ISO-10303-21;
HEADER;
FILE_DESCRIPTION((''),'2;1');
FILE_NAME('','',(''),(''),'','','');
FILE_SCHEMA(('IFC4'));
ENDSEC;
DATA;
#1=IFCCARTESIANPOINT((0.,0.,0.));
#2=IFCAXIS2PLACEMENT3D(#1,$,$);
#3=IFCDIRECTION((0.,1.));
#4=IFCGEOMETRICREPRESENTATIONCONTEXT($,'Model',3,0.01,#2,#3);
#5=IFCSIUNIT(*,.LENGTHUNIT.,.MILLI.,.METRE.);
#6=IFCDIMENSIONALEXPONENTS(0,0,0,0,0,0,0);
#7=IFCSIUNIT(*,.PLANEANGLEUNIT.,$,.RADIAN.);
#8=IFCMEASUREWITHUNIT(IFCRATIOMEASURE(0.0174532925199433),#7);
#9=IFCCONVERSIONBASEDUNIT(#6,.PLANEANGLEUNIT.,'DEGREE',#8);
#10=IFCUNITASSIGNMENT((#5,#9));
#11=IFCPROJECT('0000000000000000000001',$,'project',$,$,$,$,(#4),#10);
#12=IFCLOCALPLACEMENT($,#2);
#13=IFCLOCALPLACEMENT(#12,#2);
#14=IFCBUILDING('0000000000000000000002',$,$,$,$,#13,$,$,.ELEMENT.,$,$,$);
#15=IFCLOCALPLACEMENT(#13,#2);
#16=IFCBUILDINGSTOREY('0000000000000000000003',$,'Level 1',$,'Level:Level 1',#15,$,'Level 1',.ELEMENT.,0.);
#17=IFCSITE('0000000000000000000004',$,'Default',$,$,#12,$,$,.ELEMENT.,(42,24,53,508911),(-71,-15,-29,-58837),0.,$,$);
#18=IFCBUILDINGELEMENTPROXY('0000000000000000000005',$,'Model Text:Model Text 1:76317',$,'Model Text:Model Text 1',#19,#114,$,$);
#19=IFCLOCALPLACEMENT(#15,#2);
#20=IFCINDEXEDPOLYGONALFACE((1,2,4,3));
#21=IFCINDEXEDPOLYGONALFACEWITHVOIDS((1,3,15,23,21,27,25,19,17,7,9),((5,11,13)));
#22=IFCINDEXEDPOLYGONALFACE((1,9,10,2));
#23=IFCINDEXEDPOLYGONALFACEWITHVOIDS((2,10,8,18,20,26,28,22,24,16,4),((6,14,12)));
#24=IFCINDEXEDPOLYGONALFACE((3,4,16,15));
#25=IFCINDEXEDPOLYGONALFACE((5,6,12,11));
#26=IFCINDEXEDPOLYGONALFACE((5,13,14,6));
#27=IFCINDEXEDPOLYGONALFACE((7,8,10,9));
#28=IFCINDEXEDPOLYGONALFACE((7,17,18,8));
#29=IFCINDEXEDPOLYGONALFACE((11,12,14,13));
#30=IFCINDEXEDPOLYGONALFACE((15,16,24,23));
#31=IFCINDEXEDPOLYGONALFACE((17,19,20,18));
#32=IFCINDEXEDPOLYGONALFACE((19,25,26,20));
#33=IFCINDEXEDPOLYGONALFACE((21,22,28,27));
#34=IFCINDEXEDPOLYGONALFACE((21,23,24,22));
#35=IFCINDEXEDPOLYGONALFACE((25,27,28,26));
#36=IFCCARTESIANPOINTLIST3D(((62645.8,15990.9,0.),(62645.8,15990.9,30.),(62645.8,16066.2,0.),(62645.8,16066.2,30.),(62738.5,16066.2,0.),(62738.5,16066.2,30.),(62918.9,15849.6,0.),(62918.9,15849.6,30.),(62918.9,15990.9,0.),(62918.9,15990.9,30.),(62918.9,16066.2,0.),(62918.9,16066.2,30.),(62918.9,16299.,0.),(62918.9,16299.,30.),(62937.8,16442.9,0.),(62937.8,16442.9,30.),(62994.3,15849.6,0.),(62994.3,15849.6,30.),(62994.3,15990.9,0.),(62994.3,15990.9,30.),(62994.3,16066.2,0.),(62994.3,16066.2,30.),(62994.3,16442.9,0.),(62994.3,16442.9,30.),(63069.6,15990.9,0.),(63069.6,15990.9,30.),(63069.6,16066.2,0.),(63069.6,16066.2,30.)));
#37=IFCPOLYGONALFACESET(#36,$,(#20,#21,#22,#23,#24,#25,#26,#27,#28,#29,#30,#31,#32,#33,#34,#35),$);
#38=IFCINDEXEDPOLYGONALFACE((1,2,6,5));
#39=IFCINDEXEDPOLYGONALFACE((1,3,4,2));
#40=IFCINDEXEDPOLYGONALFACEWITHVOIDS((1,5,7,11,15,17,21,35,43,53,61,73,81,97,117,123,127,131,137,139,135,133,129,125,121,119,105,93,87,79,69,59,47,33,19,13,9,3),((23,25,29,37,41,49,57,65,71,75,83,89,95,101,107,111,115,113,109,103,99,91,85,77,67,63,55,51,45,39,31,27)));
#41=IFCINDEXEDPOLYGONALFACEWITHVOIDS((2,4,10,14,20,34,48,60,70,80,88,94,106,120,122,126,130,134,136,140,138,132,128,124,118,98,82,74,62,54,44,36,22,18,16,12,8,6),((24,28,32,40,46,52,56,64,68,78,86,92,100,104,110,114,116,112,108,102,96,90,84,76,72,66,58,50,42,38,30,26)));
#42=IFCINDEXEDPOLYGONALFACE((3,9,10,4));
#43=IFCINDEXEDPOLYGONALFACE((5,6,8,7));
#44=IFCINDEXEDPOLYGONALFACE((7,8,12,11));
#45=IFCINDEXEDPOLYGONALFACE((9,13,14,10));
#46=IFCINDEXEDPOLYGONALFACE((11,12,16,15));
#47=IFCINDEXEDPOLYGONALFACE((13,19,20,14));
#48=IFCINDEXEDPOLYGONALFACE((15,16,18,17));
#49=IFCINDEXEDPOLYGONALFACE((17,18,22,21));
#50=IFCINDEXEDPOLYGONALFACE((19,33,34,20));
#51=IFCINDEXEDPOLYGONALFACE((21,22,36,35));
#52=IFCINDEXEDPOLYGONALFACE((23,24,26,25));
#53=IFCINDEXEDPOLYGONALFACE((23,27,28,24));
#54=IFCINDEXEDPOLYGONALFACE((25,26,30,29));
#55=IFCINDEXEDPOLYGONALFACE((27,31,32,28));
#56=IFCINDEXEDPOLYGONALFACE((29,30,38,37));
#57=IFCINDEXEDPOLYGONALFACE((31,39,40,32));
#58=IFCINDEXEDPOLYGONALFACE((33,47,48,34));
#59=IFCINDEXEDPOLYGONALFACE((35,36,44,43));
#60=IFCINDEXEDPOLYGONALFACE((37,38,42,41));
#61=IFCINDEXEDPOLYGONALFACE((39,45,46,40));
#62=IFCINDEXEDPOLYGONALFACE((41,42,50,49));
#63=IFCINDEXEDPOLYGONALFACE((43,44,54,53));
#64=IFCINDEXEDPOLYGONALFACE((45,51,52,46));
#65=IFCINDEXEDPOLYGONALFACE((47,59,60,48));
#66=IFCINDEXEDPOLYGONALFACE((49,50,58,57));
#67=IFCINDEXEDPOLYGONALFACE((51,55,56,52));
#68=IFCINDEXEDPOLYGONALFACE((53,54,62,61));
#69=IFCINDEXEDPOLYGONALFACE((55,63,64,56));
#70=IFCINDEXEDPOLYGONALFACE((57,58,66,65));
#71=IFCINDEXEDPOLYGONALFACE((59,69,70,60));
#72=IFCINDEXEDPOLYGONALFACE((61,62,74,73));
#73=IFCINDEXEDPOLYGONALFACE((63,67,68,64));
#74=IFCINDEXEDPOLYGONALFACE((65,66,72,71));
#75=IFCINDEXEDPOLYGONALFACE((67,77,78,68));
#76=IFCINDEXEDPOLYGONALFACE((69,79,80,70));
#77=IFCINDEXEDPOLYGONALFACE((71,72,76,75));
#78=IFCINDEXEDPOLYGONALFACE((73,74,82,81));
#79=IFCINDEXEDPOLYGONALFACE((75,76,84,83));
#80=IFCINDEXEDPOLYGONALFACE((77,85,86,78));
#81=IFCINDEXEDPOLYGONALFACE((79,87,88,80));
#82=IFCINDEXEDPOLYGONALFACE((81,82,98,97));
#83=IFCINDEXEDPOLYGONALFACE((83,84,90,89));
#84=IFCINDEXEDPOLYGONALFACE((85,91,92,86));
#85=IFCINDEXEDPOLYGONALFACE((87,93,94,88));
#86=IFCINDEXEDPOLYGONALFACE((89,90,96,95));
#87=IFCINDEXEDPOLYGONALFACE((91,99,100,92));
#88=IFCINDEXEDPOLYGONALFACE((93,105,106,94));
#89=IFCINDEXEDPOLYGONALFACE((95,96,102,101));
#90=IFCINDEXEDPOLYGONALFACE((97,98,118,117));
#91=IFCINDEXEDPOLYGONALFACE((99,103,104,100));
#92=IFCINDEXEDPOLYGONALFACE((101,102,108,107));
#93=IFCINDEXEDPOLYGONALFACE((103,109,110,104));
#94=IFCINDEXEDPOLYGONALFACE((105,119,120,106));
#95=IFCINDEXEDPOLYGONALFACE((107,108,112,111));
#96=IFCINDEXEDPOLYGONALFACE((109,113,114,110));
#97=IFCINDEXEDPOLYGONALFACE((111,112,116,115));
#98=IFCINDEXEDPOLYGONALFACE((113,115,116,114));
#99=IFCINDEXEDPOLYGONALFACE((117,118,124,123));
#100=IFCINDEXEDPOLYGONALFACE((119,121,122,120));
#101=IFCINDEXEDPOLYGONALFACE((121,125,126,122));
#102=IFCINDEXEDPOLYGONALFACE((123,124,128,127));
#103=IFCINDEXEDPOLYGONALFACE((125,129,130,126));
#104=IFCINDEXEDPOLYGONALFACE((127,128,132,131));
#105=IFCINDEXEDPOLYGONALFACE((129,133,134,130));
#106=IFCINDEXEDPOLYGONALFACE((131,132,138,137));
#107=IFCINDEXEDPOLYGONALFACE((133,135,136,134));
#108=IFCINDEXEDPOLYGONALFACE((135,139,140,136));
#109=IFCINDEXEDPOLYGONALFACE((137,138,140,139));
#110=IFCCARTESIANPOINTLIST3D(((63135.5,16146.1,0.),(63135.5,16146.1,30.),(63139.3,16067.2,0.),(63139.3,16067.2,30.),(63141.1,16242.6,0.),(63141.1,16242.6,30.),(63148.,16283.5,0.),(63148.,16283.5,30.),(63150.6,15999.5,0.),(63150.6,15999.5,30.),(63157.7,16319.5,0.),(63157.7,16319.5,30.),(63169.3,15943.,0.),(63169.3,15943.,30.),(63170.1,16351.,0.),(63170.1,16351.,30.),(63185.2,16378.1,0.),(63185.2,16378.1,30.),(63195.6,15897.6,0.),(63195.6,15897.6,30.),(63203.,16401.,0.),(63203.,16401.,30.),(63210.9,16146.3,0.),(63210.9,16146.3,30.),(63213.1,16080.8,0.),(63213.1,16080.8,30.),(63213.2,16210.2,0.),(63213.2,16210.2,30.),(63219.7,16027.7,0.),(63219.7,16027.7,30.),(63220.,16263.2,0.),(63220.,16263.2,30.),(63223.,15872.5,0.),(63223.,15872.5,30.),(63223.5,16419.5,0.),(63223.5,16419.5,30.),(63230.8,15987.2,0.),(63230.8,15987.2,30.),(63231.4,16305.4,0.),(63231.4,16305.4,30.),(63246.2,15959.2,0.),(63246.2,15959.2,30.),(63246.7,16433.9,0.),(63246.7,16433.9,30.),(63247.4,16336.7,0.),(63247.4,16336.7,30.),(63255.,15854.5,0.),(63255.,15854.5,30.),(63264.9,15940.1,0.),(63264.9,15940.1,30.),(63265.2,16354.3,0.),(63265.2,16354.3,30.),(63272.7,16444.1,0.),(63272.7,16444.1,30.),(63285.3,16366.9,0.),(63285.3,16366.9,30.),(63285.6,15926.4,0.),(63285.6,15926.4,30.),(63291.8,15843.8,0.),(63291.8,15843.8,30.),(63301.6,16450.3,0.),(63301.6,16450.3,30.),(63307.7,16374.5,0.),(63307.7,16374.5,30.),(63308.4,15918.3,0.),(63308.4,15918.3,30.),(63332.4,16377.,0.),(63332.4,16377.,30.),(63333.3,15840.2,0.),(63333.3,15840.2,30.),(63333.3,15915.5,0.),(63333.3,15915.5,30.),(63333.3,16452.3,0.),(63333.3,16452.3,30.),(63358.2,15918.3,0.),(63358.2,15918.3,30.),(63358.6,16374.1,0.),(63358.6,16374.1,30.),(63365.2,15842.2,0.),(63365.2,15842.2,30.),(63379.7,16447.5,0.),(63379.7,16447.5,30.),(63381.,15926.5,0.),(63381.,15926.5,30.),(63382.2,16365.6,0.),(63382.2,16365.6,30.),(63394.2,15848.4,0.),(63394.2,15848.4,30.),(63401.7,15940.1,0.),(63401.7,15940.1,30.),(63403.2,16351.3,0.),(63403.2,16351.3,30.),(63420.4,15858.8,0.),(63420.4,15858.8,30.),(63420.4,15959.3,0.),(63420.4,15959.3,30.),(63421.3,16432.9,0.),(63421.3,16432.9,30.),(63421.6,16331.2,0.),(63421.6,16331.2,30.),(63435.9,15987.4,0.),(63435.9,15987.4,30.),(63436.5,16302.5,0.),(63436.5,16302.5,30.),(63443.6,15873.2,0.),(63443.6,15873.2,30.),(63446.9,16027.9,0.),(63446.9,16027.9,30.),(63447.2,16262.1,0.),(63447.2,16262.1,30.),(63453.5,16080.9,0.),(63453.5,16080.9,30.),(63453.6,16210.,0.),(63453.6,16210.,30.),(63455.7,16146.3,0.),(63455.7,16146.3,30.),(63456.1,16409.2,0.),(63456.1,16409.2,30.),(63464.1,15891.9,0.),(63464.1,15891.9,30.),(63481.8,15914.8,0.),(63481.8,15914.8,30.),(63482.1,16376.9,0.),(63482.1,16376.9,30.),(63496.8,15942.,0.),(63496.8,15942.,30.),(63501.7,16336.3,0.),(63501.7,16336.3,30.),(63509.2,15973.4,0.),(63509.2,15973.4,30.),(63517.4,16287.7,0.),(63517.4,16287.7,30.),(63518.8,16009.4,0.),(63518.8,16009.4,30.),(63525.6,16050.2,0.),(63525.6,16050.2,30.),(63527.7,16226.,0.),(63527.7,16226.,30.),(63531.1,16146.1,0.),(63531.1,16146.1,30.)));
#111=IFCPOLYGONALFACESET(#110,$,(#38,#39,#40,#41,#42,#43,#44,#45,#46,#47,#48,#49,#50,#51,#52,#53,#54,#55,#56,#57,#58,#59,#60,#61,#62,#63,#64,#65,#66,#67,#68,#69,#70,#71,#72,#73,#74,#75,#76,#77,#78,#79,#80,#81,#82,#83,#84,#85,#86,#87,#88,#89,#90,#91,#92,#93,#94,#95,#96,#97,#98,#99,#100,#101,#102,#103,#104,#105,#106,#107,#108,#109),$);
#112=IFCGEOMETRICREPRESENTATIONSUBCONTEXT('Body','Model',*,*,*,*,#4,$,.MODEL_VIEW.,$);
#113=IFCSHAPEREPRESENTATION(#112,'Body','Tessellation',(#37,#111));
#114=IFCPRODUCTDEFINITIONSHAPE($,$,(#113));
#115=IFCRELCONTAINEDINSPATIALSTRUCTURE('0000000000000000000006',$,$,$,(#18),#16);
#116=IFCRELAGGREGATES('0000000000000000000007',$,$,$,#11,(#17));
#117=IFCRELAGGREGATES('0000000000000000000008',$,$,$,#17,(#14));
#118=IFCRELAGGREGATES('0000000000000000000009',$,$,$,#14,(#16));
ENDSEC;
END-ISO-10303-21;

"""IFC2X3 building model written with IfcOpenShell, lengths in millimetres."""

from ifc_helpers import new_model, entity, si_unit, converted_unit, direction, frame, origin, place, context, subcontext, project, spatial, polyline, outline, extrude, element, save


model = new_model("IFC2X3")

# Units and contexts
model_context = context("Model", 3, precision=0.01, world=origin(), true_north=direction((0.0, 1.0)))
body_context = subcontext(model_context, "Body", "Model", "MODEL_VIEW")
ifc_project = project(units=[si_unit("LENGTHUNIT", "METRE", prefix="MILLI"), converted_unit("PLANEANGLEUNIT", "DEGREE", entity("IfcRatioMeasure", 0.0174532925199433), si_unit("PLANEANGLEUNIT", "RADIAN"), dimensions=[0, 0, 0, 0, 0, 0, 0])], contexts=[model_context])

# Site, building, storey
site_placement = place(None, origin())
site = spatial("IfcSite", under=ifc_project, at=site_placement, Name="Default", CompositionType="ELEMENT", RefLatitude=(42, 24, 53, 508911), RefLongitude=(-71, -15, -29, -58837), RefElevation=0.0)
building_placement = place(site_placement, origin())
building = spatial("IfcBuilding", under=site, at=building_placement, CompositionType="ELEMENT")
storey_placement = place(building_placement, origin())
storey = spatial("IfcBuildingStorey", under=building, at=storey_placement, Name="Level 1", ObjectType="Level:Level 1", LongName="Level 1", CompositionType="ELEMENT", Elevation=0.0)

# Building element proxy
proxy_1_placement = place(storey_placement, origin())
element("IfcBuildingElementProxy", 1, at=proxy_1_placement, inside=storey, Name="Model Text:Model Text 1:76317", ObjectType="Model Text:Model Text 1", context=body_context, shape_type="SweptSolid", body=[
    extrude(outline(polyline([(-6.8, -218.3), (68.5, -218.3), (68.5, -77.1), (143.8, -77.1), (143.8, -1.7), (68.5, -1.7), (68.5, 375.0), (12.0, 375.0), (-280.0, -1.7), (-280.0, -77.1), (-6.8, -77.1), (-6.8, -218.3)]), holes=[polyline([(-6.8, -1.7), (-187.3, -1.7), (-6.8, 231.1), (-6.8, -1.7)])]), frame((62925.8, 16067.9, 0.0)), (0.0, 0.0, 1.0), 30.0),
    extrude(outline(polyline([(-10.6, -198.7), (68.3, -198.7), (136.5, -190.7), (193.9, -174.7), (240.5, -150.6), (266.9, -124.4), (286.3, -93.2), (298.8, -57.0), (304.3, -15.7), (303.8, 16.2), (299.0, 45.5), (289.9, 72.1), (276.6, 96.0), (258.9, 117.3), (236.9, 136.2), (210.4, 152.5), (179.6, 166.3), (144.1, 177.6), (103.7, 186.3), (8.2, 196.4), (-71.8, 196.7), (-134.0, 189.4), (-183.3, 176.1), (-224.7, 158.4), (-258.2, 133.9), (-283.5, 100.3), (-300.1, 59.5), (-307.1, 13.4), (-306.6, -18.4), (-301.8, -47.5), (-292.8, -74.0), (-279.6, -97.9), (-262.0, -119.2), (-240.0, -138.1), (-213.6, -154.5), (-182.8, -168.4), (-147.3, -179.8), (-106.7, -188.6), (-10.6, -198.7)]), holes=[polyline([(-7.2, -123.5), (-71.0, -118.2), (-123.6, -108.8), (-165.2, -95.4), (-195.7, -78.0), (-212.4, -59.4), (-224.1, -38.7), (-230.6, -15.9), (-231.9, 8.9), (-227.8, 35.0), (-218.1, 58.1), (-202.8, 78.4), (-182.0, 95.8), (-152.6, 109.4), (-111.7, 118.1), (-59.4, 122.0), (4.4, 121.1), (69.6, 115.8), (122.2, 106.7), (162.2, 93.7), (189.5, 77.0), (207.7, 57.4), (220.4, 36.0), (227.5, 12.8), (229.1, -12.1), (225.2, -36.8), (215.9, -59.2), (201.3, -79.3), (181.4, -97.1), (152.6, -111.2), (111.6, -120.3), (58.3, -124.4), (-7.2, -123.5)])]), frame((63334.6, 16144.9, 0.0), z_axis=(0.0, 0.0, 1.0), x_axis=(0.047515, -0.998871, 0.0)), (0.0, 0.0, 1.0), 30.0),
])

save(model, "model.ifc")
